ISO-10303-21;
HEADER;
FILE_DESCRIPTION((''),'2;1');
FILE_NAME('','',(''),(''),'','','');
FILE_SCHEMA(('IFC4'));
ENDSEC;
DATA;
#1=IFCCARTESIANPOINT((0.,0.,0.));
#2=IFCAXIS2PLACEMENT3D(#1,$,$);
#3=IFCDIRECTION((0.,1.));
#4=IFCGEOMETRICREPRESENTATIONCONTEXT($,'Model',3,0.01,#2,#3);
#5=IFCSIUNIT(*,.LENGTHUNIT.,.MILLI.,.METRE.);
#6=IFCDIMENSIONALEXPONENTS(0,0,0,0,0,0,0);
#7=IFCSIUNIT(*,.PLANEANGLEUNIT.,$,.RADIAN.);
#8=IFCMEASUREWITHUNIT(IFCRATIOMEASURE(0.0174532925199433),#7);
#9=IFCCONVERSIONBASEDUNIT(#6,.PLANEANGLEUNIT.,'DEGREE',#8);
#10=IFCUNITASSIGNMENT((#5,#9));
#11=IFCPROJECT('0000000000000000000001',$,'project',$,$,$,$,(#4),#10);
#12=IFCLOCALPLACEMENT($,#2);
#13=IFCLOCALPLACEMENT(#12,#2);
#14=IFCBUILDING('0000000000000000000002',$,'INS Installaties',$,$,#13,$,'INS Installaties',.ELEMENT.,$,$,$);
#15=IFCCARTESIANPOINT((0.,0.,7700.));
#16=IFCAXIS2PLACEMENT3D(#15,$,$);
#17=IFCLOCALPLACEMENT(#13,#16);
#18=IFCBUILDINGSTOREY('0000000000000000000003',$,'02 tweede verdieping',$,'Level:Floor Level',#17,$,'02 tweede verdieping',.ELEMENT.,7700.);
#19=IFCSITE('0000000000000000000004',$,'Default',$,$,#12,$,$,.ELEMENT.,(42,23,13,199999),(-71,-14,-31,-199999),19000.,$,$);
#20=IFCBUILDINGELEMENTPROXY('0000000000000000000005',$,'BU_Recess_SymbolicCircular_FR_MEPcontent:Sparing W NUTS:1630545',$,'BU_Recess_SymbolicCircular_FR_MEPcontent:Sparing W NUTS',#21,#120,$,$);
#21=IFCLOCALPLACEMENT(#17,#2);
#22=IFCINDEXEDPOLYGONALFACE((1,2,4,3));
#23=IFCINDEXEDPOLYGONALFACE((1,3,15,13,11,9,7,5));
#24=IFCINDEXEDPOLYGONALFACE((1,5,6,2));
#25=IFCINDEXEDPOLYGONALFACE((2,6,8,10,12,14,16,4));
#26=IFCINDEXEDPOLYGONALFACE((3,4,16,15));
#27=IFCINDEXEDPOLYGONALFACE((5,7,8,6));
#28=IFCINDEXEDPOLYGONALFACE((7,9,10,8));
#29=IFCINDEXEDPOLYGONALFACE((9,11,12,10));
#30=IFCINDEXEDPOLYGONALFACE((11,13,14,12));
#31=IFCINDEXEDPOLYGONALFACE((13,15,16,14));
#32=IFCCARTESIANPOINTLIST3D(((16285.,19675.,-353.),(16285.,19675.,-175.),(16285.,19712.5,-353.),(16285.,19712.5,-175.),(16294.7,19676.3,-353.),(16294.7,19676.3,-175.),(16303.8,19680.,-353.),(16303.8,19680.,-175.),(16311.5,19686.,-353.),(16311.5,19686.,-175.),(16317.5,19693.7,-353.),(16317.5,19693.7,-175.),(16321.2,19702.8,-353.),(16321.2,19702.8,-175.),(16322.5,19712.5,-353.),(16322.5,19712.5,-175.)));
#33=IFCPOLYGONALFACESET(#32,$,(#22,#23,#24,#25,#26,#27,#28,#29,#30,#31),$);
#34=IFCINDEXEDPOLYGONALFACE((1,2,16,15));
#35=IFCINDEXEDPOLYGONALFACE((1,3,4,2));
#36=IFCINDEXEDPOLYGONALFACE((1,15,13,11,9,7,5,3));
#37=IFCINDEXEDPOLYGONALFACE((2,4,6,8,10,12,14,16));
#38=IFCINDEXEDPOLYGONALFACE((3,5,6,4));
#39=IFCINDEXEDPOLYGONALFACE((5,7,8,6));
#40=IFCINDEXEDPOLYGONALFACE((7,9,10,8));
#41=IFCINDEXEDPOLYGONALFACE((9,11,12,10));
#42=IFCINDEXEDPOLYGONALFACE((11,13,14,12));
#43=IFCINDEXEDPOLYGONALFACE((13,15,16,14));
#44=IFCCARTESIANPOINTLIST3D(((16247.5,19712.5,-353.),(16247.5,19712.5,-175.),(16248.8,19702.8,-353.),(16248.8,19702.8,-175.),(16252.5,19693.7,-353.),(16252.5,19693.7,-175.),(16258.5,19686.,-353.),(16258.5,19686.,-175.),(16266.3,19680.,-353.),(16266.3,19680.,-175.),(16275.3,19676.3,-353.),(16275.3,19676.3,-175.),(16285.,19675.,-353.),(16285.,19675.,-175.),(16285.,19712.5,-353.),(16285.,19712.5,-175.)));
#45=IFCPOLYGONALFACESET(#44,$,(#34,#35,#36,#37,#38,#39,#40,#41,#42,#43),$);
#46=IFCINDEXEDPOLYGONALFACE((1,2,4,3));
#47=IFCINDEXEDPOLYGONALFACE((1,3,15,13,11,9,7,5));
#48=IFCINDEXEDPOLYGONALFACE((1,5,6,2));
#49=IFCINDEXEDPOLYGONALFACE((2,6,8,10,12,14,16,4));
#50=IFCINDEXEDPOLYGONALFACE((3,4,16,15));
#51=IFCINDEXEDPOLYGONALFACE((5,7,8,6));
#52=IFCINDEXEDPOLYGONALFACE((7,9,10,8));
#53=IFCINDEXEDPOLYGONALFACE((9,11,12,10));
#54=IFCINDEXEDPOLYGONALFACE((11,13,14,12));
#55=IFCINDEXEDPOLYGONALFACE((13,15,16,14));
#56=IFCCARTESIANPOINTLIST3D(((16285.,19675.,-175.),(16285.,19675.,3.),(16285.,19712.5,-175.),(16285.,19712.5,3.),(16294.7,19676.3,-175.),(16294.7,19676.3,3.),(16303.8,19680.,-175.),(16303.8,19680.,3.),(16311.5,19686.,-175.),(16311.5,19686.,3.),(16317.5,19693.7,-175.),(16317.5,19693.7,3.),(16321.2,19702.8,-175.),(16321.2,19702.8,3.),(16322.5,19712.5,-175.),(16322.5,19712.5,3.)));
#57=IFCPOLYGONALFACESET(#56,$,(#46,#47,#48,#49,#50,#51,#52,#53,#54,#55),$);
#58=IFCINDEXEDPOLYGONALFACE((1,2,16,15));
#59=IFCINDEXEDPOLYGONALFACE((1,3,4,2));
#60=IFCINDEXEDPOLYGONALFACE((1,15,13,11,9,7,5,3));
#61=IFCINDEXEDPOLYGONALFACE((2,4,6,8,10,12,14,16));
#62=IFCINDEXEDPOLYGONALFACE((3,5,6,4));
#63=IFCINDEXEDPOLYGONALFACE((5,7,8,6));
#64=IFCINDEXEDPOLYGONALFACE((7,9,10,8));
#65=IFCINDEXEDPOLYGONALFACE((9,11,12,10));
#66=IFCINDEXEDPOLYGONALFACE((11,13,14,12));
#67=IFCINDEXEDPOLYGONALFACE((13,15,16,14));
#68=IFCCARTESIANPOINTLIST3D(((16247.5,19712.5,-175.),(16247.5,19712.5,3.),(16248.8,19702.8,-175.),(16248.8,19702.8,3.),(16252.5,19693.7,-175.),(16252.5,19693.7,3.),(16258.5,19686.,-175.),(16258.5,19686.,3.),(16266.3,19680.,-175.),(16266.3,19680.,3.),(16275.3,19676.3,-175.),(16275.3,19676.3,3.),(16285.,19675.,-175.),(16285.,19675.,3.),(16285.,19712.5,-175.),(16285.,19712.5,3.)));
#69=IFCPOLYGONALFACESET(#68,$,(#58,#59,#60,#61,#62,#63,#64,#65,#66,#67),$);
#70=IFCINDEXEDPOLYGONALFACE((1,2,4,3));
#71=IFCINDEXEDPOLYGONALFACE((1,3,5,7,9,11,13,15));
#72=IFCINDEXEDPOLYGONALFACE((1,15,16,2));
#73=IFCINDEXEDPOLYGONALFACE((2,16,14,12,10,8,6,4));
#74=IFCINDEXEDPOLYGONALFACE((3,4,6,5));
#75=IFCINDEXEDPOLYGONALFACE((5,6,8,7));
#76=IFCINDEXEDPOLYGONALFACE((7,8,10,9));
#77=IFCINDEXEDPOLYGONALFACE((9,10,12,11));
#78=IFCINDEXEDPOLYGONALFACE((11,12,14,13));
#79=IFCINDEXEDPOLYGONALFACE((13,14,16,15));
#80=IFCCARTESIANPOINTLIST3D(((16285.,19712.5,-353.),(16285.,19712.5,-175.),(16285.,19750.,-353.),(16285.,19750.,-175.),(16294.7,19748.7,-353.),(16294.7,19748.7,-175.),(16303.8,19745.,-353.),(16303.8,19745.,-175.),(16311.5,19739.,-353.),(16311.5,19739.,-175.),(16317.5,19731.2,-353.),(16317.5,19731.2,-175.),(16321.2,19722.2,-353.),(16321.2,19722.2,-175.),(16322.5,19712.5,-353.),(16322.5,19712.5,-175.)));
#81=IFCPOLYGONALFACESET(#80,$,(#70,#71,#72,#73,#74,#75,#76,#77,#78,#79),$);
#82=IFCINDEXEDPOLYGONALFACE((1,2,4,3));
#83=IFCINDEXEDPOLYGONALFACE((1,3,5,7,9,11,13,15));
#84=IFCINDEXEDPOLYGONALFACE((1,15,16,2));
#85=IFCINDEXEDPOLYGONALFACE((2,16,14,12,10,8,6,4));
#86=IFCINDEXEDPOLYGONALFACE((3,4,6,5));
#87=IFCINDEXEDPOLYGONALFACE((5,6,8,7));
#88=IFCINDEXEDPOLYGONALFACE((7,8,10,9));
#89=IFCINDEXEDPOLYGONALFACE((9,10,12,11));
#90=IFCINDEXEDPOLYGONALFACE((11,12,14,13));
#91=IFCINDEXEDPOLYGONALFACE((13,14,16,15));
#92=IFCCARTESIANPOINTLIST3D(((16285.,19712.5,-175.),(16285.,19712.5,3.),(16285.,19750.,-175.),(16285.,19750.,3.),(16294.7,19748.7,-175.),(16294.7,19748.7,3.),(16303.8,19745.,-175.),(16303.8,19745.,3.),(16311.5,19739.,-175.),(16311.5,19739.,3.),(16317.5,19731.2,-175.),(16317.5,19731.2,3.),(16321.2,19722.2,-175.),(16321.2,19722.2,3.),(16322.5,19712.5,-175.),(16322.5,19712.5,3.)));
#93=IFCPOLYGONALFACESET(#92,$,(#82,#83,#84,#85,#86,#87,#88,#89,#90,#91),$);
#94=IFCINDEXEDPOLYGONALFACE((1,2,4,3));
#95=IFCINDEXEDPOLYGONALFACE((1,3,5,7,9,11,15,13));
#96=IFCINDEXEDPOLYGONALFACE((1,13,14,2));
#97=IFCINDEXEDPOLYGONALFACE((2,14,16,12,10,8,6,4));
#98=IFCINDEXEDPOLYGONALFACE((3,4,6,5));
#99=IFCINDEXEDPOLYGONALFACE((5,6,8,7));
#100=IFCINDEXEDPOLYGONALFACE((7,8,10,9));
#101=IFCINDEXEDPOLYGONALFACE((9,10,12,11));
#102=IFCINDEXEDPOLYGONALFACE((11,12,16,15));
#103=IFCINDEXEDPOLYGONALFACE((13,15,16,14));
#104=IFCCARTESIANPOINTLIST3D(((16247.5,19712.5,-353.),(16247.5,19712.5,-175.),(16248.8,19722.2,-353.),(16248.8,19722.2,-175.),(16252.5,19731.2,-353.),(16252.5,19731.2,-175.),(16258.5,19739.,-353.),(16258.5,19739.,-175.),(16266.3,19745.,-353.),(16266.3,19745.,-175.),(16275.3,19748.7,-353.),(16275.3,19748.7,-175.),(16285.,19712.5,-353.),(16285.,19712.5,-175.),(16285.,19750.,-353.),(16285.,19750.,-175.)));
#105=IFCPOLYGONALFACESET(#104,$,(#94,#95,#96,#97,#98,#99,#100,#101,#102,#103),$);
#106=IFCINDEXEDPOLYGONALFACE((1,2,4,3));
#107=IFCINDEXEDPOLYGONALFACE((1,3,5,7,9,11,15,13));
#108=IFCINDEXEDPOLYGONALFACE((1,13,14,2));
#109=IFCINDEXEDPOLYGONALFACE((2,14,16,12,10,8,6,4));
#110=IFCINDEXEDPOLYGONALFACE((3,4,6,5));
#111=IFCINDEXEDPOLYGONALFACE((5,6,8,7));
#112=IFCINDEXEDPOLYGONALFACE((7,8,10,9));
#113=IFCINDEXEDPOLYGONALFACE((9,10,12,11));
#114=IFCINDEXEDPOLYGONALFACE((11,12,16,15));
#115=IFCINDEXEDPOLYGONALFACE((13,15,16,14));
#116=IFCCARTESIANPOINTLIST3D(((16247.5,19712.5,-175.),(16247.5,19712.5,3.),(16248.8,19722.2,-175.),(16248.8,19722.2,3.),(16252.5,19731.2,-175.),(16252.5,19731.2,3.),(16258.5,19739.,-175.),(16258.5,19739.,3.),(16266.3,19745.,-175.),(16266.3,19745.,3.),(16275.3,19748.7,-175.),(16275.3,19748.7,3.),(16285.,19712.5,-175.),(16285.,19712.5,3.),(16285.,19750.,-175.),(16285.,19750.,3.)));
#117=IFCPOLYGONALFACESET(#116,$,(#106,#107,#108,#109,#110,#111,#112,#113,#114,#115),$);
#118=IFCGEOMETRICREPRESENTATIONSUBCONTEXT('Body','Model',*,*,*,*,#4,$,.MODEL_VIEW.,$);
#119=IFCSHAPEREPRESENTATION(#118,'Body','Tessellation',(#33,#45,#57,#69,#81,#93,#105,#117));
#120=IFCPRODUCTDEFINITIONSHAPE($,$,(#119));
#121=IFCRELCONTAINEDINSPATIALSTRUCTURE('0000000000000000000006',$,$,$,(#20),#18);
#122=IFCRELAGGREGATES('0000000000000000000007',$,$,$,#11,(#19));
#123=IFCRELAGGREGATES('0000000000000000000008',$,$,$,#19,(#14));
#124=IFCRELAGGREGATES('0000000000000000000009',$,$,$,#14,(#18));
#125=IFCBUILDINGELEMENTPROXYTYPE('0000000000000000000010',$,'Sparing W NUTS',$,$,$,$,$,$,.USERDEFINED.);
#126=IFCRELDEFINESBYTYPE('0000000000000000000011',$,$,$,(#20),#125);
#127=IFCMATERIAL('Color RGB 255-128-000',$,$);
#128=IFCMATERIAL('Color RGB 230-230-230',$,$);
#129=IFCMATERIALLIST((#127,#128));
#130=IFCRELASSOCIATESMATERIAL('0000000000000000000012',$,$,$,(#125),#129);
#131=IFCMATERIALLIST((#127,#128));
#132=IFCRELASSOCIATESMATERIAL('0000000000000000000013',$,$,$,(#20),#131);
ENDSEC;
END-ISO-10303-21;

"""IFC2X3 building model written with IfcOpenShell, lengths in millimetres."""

from ifc_helpers import new_model, entity, si_unit, converted_unit, direction, frame, frame_2d, origin, place, context, subcontext, project, spatial, polyline, circle_curve, parameter, trimmed, segment, composite_curve, outline, extrude, source, transform, mapped, material, material_list, type_object, type_shapes, element, save


model = new_model("IFC2X3")

# Units and contexts
model_context = context("Model", 3, precision=0.01, world=origin(), true_north=direction((0.0, 1.0)))
body_context = subcontext(model_context, "Body", "Model", "MODEL_VIEW")
ifc_project = project(units=[si_unit("LENGTHUNIT", "METRE", prefix="MILLI"), converted_unit("PLANEANGLEUNIT", "DEGREE", entity("IfcRatioMeasure", 0.0174532925199433), si_unit("PLANEANGLEUNIT", "RADIAN"), dimensions=[0, 0, 0, 0, 0, 0, 0])], contexts=[model_context])

# Site, building, storey
site_placement = place(None, origin())
site = spatial("IfcSite", under=ifc_project, at=site_placement, Name="Default", CompositionType="ELEMENT", RefLatitude=(42, 23, 13, 199999), RefLongitude=(-71, -14, -31, -199999), RefElevation=19000.0)
building_placement = place(site_placement, origin())
building = spatial("IfcBuilding", under=site, at=building_placement, Name="INS Installaties", LongName="INS Installaties", CompositionType="ELEMENT")
storey_placement = place(building_placement, frame((0.0, 0.0, 7700.0)))
storey = spatial("IfcBuildingStorey", under=building, at=storey_placement, Name="02 tweede verdieping", ObjectType="Level:Floor Level", LongName="02 tweede verdieping", CompositionType="ELEMENT", Elevation=7700.0)

# Building element proxy
ifc_material_1 = material(Name="Color RGB 255-128-000")
ifc_material_2 = material(Name="Color RGB 230-230-230")
ifc_material_list_1 = material_list([ifc_material_1, ifc_material_2])
ifc_material_list_2 = material_list([ifc_material_1, ifc_material_2])
building_element_proxy_type_1 = type_object("IfcBuildingElementProxyType", Name="Sparing W NUTS", PredefinedType="USERDEFINED", material=ifc_material_list_2)
shared_shape_1 = source(origin(), body_context, "Body", "SweptSolid", [
    extrude(outline(composite_curve([segment(polyline([(-25.0, -12.5), (12.5, -12.5)]), True, "CONTINUOUS"), segment(polyline([(12.5, -12.5), (12.5, 25.0)]), True, "CONTINUOUS"), segment(trimmed(circle_curve(frame_2d((12.5, -12.5), x_axis=(1.0, 0.0)), 37.5), [parameter(90.0)], [parameter(180.0)], True, "PARAMETER"), True, "CONTINUOUS")], self_intersect=False)), frame((12.5, -12.5, -353.0), z_axis=(0.0, 0.0, 1.0), x_axis=(-1.0, 0.0, 0.0)), (0.0, 0.0, 1.0), 178.0),
    extrude(outline(composite_curve([segment(trimmed(circle_curve(frame_2d((12.5, 12.5), x_axis=(1.0, 0.0)), 37.5), [parameter(180.0)], [parameter(270.0)], True, "PARAMETER"), True, "CONTINUOUS"), segment(polyline([(12.5, -25.0), (12.5, 12.5)]), True, "CONTINUOUS"), segment(polyline([(12.5, 12.5), (-25.0, 12.5)]), True, "CONTINUOUS")], self_intersect=False)), frame((-12.5, -12.5, -353.0)), (0.0, 0.0, 1.0), 178.0),
    extrude(outline(composite_curve([segment(polyline([(-25.0, -12.5), (12.5, -12.5)]), True, "CONTINUOUS"), segment(polyline([(12.5, -12.5), (12.5, 25.0)]), True, "CONTINUOUS"), segment(trimmed(circle_curve(frame_2d((12.5, -12.5), x_axis=(1.0, 0.0)), 37.5), [parameter(90.0)], [parameter(180.0)], True, "PARAMETER"), True, "CONTINUOUS")], self_intersect=False)), frame((12.5, -12.5, -175.0), z_axis=(0.0, 0.0, 1.0), x_axis=(-1.0, 0.0, 0.0)), (0.0, 0.0, 1.0), 178.0),
    extrude(outline(composite_curve([segment(trimmed(circle_curve(frame_2d((12.5, 12.5), x_axis=(1.0, 0.0)), 37.5), [parameter(180.0)], [parameter(270.0)], True, "PARAMETER"), True, "CONTINUOUS"), segment(polyline([(12.5, -25.0), (12.5, 12.5)]), True, "CONTINUOUS"), segment(polyline([(12.5, 12.5), (-25.0, 12.5)]), True, "CONTINUOUS")], self_intersect=False)), frame((-12.5, -12.5, -175.0)), (0.0, 0.0, 1.0), 178.0),
    extrude(outline(composite_curve([segment(trimmed(circle_curve(frame_2d((12.5, 12.5), x_axis=(1.0, 0.0)), 37.5), [parameter(180.0)], [parameter(270.0)], True, "PARAMETER"), True, "CONTINUOUS"), segment(polyline([(12.5, -25.0), (12.5, 12.5)]), True, "CONTINUOUS"), segment(polyline([(12.5, 12.5), (-25.0, 12.5)]), True, "CONTINUOUS")], self_intersect=False)), frame((12.5, 12.5, -353.0), z_axis=(0.0, 0.0, 1.0), x_axis=(-1.0, 0.0, 0.0)), (0.0, 0.0, 1.0), 178.0),
    extrude(outline(composite_curve([segment(trimmed(circle_curve(frame_2d((12.5, 12.5), x_axis=(1.0, 0.0)), 37.5), [parameter(180.0)], [parameter(270.0)], True, "PARAMETER"), True, "CONTINUOUS"), segment(polyline([(12.5, -25.0), (12.5, 12.5)]), True, "CONTINUOUS"), segment(polyline([(12.5, 12.5), (-25.0, 12.5)]), True, "CONTINUOUS")], self_intersect=False)), frame((12.5, 12.5, -175.0), z_axis=(0.0, 0.0, 1.0), x_axis=(-1.0, 0.0, 0.0)), (0.0, 0.0, 1.0), 178.0),
    extrude(outline(composite_curve([segment(polyline([(-25.0, -12.5), (12.5, -12.5)]), True, "CONTINUOUS"), segment(polyline([(12.5, -12.5), (12.5, 25.0)]), True, "CONTINUOUS"), segment(trimmed(circle_curve(frame_2d((12.5, -12.5), x_axis=(1.0, 0.0)), 37.5), [parameter(90.0)], [parameter(180.0)], True, "PARAMETER"), True, "CONTINUOUS")], self_intersect=False)), frame((-12.5, 12.5, -353.0)), (0.0, 0.0, 1.0), 178.0),
    extrude(outline(composite_curve([segment(polyline([(-25.0, -12.5), (12.5, -12.5)]), True, "CONTINUOUS"), segment(polyline([(12.5, -12.5), (12.5, 25.0)]), True, "CONTINUOUS"), segment(trimmed(circle_curve(frame_2d((12.5, -12.5), x_axis=(1.0, 0.0)), 37.5), [parameter(90.0)], [parameter(180.0)], True, "PARAMETER"), True, "CONTINUOUS")], self_intersect=False)), frame((-12.5, 12.5, -175.0)), (0.0, 0.0, 1.0), 178.0),
])
type_shapes(building_element_proxy_type_1, [shared_shape_1])
proxy_1_placement = place(storey_placement, frame((16285.0, 19712.5, 0.0)))
element("IfcBuildingElementProxy", 1, at=proxy_1_placement, inside=storey, type_object=building_element_proxy_type_1, material=ifc_material_list_1, Name="BU_Recess_SymbolicCircular_FR_MEPcontent:Sparing W NUTS:1630545", ObjectType="BU_Recess_SymbolicCircular_FR_MEPcontent:Sparing W NUTS", context=body_context, shape_type="MappedRepresentation", body=[
    mapped(shared_shape_1, transform((0.0, 0.0, 0.0), scale=1.0)),
])

save(model, "model.ifc")
